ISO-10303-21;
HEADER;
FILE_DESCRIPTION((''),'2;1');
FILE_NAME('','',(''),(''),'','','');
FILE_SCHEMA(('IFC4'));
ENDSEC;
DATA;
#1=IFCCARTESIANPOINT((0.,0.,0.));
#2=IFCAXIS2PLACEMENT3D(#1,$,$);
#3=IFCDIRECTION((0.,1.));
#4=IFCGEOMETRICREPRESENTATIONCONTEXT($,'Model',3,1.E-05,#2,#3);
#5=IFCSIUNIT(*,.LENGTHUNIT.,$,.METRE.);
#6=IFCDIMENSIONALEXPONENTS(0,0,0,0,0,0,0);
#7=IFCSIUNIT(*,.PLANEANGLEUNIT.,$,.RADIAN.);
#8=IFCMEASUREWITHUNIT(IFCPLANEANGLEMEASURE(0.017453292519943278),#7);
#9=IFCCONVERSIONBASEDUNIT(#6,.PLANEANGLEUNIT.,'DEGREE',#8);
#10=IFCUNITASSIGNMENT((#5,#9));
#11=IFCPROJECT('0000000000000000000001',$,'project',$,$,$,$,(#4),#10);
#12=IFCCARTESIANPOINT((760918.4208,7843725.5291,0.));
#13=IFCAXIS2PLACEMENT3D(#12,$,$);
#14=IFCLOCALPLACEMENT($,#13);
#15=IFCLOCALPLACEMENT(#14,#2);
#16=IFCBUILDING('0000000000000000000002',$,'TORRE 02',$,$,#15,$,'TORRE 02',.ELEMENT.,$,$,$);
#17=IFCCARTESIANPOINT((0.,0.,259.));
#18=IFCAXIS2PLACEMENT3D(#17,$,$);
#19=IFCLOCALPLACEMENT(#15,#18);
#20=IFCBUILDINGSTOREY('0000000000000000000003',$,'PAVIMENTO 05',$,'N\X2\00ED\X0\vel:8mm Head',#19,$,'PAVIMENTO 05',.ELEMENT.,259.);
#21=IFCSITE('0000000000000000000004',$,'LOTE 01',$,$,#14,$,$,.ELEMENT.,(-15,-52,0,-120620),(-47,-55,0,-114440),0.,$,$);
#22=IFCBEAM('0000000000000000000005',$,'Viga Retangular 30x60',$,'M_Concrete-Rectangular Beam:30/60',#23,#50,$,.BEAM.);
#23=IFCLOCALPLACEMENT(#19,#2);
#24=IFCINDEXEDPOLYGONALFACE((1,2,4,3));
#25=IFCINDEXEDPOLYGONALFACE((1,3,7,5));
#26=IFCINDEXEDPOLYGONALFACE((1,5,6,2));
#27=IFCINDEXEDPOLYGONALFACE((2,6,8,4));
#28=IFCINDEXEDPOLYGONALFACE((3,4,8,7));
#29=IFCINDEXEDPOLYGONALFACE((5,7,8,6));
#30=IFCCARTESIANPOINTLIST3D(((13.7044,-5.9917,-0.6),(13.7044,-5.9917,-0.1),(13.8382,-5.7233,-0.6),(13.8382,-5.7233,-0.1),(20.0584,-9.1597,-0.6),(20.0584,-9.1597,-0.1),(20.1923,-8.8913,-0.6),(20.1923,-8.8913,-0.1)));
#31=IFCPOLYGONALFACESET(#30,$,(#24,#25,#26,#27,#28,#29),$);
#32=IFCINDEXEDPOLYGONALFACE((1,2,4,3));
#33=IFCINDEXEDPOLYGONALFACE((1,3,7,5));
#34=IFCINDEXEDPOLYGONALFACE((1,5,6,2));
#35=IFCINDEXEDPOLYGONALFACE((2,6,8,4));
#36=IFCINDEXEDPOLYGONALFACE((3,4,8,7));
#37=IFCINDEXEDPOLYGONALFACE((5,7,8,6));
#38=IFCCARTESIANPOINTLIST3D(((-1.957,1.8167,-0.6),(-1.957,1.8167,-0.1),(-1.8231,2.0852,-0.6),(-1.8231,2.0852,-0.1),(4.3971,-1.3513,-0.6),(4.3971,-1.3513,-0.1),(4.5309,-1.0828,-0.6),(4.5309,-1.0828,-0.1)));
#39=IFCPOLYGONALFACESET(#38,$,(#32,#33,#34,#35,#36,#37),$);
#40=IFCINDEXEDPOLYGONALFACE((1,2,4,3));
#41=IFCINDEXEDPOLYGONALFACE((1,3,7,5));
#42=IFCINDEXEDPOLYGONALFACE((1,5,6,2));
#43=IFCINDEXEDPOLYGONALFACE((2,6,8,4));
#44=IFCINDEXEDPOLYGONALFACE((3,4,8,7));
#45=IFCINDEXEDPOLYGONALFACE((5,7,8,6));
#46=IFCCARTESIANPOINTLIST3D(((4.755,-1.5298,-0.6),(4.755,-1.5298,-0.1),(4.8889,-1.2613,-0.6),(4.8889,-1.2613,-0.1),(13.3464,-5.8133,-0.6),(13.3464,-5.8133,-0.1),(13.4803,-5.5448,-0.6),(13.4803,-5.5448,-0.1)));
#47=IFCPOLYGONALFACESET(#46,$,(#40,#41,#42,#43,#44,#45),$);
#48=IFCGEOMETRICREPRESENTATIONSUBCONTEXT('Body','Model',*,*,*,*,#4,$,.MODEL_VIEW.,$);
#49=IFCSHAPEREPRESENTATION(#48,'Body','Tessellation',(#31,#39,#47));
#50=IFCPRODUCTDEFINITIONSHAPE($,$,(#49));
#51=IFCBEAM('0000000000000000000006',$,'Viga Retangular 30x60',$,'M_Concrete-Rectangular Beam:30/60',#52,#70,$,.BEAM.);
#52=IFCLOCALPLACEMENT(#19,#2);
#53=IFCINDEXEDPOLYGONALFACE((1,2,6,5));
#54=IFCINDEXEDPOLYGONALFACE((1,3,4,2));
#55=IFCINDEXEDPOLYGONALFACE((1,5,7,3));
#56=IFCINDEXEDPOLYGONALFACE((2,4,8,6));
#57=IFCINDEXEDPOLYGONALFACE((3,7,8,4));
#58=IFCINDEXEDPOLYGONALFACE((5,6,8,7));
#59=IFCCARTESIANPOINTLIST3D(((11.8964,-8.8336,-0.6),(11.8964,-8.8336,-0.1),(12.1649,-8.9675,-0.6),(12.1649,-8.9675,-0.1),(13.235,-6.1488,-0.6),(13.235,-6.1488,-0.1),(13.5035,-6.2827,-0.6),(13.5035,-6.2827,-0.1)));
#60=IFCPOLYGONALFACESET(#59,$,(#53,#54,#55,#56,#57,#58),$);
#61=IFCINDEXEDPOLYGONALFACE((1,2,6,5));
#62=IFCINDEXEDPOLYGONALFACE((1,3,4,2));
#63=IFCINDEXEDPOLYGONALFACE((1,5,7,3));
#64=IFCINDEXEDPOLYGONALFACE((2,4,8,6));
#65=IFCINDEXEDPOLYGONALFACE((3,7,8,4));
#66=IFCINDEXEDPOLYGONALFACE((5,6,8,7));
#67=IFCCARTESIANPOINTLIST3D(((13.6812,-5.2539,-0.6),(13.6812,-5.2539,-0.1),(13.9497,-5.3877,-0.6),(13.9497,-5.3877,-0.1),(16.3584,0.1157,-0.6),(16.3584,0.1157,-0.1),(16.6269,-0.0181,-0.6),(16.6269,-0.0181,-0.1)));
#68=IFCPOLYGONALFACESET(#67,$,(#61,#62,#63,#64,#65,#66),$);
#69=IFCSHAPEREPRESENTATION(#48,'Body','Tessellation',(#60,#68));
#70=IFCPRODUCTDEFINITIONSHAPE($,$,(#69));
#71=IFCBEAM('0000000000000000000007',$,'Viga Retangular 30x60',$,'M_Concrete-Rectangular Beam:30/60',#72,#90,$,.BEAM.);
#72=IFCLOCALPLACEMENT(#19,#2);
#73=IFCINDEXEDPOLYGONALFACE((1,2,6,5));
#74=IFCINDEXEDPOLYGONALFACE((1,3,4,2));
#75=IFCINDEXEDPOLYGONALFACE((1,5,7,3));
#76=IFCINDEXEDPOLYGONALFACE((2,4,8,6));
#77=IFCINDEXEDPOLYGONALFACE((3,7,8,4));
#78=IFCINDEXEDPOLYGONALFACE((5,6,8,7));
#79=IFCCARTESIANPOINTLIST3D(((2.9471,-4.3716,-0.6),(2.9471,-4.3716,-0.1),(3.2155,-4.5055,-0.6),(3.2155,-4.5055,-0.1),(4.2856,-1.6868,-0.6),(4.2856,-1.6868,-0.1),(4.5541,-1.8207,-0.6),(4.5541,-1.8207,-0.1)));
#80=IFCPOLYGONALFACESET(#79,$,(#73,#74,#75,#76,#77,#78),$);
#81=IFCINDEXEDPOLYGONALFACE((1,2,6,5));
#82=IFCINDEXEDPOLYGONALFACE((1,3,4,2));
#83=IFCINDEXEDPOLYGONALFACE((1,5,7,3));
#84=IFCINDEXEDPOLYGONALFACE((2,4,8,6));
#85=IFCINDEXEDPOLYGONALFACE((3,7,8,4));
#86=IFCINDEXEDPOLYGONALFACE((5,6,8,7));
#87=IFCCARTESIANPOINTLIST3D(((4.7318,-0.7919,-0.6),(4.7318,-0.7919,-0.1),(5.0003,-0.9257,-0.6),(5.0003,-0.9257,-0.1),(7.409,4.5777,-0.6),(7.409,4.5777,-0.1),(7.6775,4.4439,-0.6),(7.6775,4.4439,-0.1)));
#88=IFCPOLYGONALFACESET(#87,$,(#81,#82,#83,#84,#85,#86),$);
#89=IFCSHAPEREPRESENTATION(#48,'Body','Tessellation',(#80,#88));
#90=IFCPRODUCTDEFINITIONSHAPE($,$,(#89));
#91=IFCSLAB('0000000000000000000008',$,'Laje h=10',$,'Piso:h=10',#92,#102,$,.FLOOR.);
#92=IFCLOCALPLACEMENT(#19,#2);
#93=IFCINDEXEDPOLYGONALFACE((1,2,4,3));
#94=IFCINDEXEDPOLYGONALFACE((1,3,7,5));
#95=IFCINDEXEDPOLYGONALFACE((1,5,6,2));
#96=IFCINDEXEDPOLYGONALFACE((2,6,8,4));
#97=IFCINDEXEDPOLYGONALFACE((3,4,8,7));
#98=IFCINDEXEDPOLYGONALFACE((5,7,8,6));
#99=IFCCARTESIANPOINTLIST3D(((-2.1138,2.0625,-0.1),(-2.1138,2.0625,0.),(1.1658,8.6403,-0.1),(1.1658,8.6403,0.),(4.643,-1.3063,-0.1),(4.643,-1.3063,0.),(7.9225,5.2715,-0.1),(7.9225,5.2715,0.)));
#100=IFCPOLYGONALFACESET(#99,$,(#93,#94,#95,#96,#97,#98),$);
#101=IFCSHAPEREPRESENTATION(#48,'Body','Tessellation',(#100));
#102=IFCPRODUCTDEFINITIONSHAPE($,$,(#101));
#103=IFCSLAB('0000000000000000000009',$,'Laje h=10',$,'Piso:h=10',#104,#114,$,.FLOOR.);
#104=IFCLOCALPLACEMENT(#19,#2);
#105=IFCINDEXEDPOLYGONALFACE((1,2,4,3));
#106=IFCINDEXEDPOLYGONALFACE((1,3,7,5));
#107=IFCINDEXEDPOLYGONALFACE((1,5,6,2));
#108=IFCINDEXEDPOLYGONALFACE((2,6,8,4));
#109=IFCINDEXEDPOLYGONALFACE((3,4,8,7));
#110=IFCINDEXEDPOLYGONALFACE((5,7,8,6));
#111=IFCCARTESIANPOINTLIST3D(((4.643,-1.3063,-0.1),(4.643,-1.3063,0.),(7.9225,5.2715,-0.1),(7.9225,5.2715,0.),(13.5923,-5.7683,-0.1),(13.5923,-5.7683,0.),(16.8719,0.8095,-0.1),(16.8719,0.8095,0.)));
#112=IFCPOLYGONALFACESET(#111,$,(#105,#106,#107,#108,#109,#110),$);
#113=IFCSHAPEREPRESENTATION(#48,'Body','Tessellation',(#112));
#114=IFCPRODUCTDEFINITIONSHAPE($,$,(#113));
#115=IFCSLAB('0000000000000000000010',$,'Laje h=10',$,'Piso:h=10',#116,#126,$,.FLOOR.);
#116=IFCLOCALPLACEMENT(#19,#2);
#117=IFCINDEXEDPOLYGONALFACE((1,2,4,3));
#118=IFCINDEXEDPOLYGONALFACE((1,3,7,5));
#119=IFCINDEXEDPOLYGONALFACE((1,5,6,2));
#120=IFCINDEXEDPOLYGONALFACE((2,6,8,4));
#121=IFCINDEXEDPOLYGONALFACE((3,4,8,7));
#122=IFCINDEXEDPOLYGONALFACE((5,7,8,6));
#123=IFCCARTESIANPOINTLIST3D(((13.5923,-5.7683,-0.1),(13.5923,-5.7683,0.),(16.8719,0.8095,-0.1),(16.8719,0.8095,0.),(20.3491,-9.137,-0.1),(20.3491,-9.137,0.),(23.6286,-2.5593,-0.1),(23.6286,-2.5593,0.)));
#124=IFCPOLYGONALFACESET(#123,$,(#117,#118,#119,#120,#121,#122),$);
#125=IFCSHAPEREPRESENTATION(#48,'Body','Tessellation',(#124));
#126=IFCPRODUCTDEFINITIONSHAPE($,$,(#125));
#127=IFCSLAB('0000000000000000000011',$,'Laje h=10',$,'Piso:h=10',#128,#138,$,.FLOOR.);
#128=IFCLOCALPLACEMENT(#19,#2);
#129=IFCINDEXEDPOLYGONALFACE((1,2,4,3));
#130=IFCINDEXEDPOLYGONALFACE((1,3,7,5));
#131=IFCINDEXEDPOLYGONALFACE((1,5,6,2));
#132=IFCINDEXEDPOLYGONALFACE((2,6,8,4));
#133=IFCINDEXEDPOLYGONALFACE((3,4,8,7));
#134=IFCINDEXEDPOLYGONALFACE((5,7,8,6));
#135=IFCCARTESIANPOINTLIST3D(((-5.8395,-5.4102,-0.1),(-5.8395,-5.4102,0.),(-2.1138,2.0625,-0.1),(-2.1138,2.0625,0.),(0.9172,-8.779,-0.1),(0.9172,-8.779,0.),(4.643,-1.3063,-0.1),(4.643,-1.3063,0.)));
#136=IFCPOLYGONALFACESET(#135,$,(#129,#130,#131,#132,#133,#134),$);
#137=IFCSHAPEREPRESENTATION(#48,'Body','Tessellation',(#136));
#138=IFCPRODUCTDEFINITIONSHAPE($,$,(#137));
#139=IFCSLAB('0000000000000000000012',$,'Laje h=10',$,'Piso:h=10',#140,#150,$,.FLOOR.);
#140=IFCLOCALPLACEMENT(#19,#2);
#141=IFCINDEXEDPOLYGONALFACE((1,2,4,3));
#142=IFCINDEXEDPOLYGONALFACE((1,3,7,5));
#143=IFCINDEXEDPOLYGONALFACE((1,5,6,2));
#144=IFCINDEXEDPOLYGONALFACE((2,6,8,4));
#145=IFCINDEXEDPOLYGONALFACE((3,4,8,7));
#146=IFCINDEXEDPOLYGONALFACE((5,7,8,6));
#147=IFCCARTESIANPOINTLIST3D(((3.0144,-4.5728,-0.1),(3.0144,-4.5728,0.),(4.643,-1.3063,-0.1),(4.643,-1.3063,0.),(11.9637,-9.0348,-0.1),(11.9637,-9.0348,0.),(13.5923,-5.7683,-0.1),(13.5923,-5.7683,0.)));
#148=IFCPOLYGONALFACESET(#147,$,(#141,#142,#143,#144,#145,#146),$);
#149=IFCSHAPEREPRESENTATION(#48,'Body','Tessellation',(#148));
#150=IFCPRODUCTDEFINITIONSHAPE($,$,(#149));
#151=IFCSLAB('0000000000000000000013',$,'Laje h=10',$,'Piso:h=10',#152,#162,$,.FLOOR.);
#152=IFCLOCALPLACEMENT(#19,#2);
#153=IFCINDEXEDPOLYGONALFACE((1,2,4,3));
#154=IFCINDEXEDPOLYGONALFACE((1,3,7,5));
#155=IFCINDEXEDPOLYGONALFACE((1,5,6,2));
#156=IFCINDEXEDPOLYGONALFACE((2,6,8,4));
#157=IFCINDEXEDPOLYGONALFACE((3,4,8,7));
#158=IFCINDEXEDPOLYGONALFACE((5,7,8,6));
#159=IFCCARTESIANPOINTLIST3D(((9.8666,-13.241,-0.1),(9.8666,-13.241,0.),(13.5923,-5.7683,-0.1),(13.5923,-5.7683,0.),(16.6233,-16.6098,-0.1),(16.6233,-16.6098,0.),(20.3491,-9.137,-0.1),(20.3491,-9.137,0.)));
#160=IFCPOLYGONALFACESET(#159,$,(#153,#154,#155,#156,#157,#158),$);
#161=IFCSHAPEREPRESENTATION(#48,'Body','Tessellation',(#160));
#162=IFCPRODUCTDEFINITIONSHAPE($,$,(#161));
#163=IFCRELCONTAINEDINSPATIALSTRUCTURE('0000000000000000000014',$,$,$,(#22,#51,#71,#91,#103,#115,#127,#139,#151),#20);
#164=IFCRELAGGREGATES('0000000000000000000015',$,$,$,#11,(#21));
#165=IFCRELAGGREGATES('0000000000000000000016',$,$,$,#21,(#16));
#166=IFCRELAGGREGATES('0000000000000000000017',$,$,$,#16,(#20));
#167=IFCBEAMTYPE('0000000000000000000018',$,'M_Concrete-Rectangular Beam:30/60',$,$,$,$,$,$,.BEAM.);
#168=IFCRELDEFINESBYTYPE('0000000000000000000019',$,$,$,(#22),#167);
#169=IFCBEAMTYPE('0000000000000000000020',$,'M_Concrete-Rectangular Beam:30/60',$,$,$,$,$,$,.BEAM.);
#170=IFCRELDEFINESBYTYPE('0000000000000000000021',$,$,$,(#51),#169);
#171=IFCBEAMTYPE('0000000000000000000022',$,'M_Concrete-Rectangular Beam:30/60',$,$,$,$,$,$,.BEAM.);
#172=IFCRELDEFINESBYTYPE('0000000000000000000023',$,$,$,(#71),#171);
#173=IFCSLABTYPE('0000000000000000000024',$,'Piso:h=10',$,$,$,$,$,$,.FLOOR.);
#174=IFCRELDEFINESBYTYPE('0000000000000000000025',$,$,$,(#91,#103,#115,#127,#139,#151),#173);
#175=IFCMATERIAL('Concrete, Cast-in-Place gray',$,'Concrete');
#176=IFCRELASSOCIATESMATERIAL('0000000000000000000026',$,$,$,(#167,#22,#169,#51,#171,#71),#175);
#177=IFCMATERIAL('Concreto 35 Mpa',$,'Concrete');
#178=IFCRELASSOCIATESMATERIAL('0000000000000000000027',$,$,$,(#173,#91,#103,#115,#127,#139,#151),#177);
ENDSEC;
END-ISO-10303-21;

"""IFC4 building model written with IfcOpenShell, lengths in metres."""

from ifc_helpers import new_model, entity, si_unit, converted_unit, direction, frame, origin, place, context, subcontext, project, spatial, indexed_curve, outline, extrude, source, transform, mapped, material, type_object, type_shapes, element, save


model = new_model("IFC4")

# Units and contexts
model_context = context("Model", 3, precision=1e-05, world=origin(), true_north=direction((0.0, 1.0)))
body_context = subcontext(model_context, "Body", "Model", "MODEL_VIEW")
ifc_project = project(units=[si_unit("LENGTHUNIT", "METRE"), converted_unit("PLANEANGLEUNIT", "DEGREE", entity("IfcPlaneAngleMeasure", 0.017453292519943278), si_unit("PLANEANGLEUNIT", "RADIAN"), dimensions=[0, 0, 0, 0, 0, 0, 0])], contexts=[model_context])

# Site, building, storey
site_placement = place(None, frame((760918.4208, 7843725.5291, 0.0)))
site = spatial("IfcSite", under=ifc_project, at=site_placement, Name="LOTE 01", CompositionType="ELEMENT", RefLatitude=(-15, -52, 0, -120620), RefLongitude=(-47, -55, 0, -114440), RefElevation=0.0)
building_placement = place(site_placement, origin())
building = spatial("IfcBuilding", under=site, at=building_placement, Name="TORRE 02", LongName="TORRE 02", CompositionType="ELEMENT")
storey_placement = place(building_placement, frame((0.0, 0.0, 259.0)))
storey = spatial("IfcBuildingStorey", under=building, at=storey_placement, Name="PAVIMENTO 05", ObjectType="Nível:8mm Head", LongName="PAVIMENTO 05", CompositionType="ELEMENT", Elevation=259.0)

# Shared definitions
ifc_material_1 = material(Name="Concrete, Cast-in-Place gray", Category="Concrete")

# Beams
beam_type_1 = type_object("IfcBeamType", Name="M_Concrete-Rectangular Beam:30/60", PredefinedType="BEAM", material=ifc_material_1)
shared_shape_1 = source(origin(), body_context, "Body", "SweptSolid", [
    extrude(outline(indexed_curve([(-0.25, -0.15), (0.25, -0.15), (0.25, 0.15), (-0.25, 0.15), (-0.25, -0.15)], self_intersect=False)), frame((13.7713, -5.8575, 258.65), z_axis=(0.894934, -0.446198, 0.0), x_axis=(0.0, 0.0, -1.0)), (0.0, 0.0, 1.0), 7.1),
    extrude(outline(indexed_curve([(-0.25, -0.15), (0.25, -0.15), (0.25, 0.15), (-0.25, 0.15), (-0.25, -0.15)], self_intersect=False)), frame((-1.89, 1.951, 258.65), z_axis=(0.894934, -0.446198, 0.0), x_axis=(0.0, 0.0, -1.0)), (0.0, 0.0, 1.0), 7.1),
    extrude(outline(indexed_curve([(-0.25, -0.15), (0.25, -0.15), (0.25, 0.15), (-0.25, 0.15), (-0.25, -0.15)], self_intersect=False)), frame((4.822, -1.3955, 258.65), z_axis=(0.894934, -0.446198, 0.0), x_axis=(0.0, 0.0, -1.0)), (0.0, 0.0, 1.0), 9.6),
])
type_shapes(beam_type_1, [shared_shape_1])
beam_1_placement = place(storey_placement, frame((0.0, 0.0, -259.0)))
element("IfcBeam", 1, at=beam_1_placement, inside=storey, type_object=beam_type_1, material=ifc_material_1, Name="Viga Retangular 30x60", ObjectType="M_Concrete-Rectangular Beam:30/60", PredefinedType="BEAM", context=body_context, shape_type="MappedRepresentation", body=[
    mapped(shared_shape_1, transform((0.0, 0.0, 0.0), scale=1.0)),
])
beam_type_2 = type_object("IfcBeamType", Name="M_Concrete-Rectangular Beam:30/60", PredefinedType="BEAM", material=ifc_material_1)
shared_shape_2 = source(origin(), body_context, "Body", "SweptSolid", [
    extrude(outline(indexed_curve([(-0.25, -0.15), (0.25, -0.15), (0.25, 0.15), (-0.25, 0.15), (-0.25, -0.15)], self_intersect=False)), frame((12.0306, -8.9005, 258.65), z_axis=(0.446198, 0.894934, 0.0), x_axis=(0.0, 0.0, 1.0)), (0.0, 0.0, 1.0), 3.0),
    extrude(outline(indexed_curve([(-0.25, -0.15), (0.25, -0.15), (0.25, 0.15), (-0.25, 0.15), (-0.25, -0.15)], self_intersect=False)), frame((13.8154, -5.3208, 258.65), z_axis=(0.446198, 0.894934, 0.0), x_axis=(0.0, 0.0, 1.0)), (0.0, 0.0, 1.0), 6.0),
])
type_shapes(beam_type_2, [shared_shape_2])
beam_2_placement = place(storey_placement, frame((0.0, 0.0, -259.0)))
element("IfcBeam", 2, at=beam_2_placement, inside=storey, type_object=beam_type_2, material=ifc_material_1, Name="Viga Retangular 30x60", ObjectType="M_Concrete-Rectangular Beam:30/60", PredefinedType="BEAM", context=body_context, shape_type="MappedRepresentation", body=[
    mapped(shared_shape_2, transform((0.0, 0.0, 0.0), scale=1.0)),
])
beam_type_3 = type_object("IfcBeamType", Name="M_Concrete-Rectangular Beam:30/60", PredefinedType="BEAM", material=ifc_material_1)
shared_shape_3 = source(origin(), body_context, "Body", "SweptSolid", [
    extrude(outline(indexed_curve([(-0.25, -0.15), (0.25, -0.15), (0.25, 0.15), (-0.25, 0.15), (-0.25, -0.15)], self_intersect=False)), frame((3.0813, -4.4385, 258.65), z_axis=(0.446198, 0.894934, 0.0), x_axis=(0.0, 0.0, 1.0)), (0.0, 0.0, 1.0), 3.0),
    extrude(outline(indexed_curve([(-0.25, -0.15), (0.25, -0.15), (0.25, 0.15), (-0.25, 0.15), (-0.25, -0.15)], self_intersect=False)), frame((4.8661, -0.8588, 258.65), z_axis=(0.446198, 0.894934, 0.0), x_axis=(0.0, 0.0, 1.0)), (0.0, 0.0, 1.0), 6.0),
])
type_shapes(beam_type_3, [shared_shape_3])
beam_3_placement = place(storey_placement, frame((0.0, 0.0, -259.0)))
element("IfcBeam", 3, at=beam_3_placement, inside=storey, type_object=beam_type_3, material=ifc_material_1, Name="Viga Retangular 30x60", ObjectType="M_Concrete-Rectangular Beam:30/60", PredefinedType="BEAM", context=body_context, shape_type="MappedRepresentation", body=[
    mapped(shared_shape_3, transform((0.0, 0.0, 0.0), scale=1.0)),
])

# Slabs
ifc_material_2 = material(Name="Concreto 35 Mpa", Category="Concrete")
slab_type = type_object("IfcSlabType", Name="Piso:h=10", PredefinedType="FLOOR", material=ifc_material_2)
slab_1_placement = place(storey_placement, origin())
element("IfcSlab", 4, at=slab_1_placement, inside=storey, type_object=slab_type, material=ifc_material_2, Name="Laje h=10", ObjectType="Piso:h=10", PredefinedType="FLOOR", context=body_context, shape_type="SweptSolid", body=[
    extrude(outline(indexed_curve([(-3.675, -3.775), (3.675, -3.775), (3.675, 3.775), (-3.675, 3.775), (-3.675, -3.775)], self_intersect=False)), frame((2.9044, 3.667, 0.0), z_axis=(0.0, 0.0, -1.0), x_axis=(-0.446198, -0.894934, 0.0)), (0.0, 0.0, 1.0), 0.1),
])
slab_2_placement = place(storey_placement, origin())
element("IfcSlab", 5, at=slab_2_placement, inside=storey, type_object=slab_type, material=ifc_material_2, Name="Laje h=10", ObjectType="Piso:h=10", PredefinedType="FLOOR", context=body_context, shape_type="SweptSolid", body=[
    extrude(outline(indexed_curve([(-3.675, -5.0), (3.675, -5.0), (3.675, 5.0), (-3.675, 5.0), (-3.675, -5.0)], self_intersect=False)), frame((10.7574, -0.2484, 0.0), z_axis=(0.0, 0.0, -1.0), x_axis=(-0.446198, -0.894934, 0.0)), (0.0, 0.0, 1.0), 0.1),
])
slab_3_placement = place(storey_placement, origin())
element("IfcSlab", 6, at=slab_3_placement, inside=storey, type_object=slab_type, material=ifc_material_2, Name="Laje h=10", ObjectType="Piso:h=10", PredefinedType="FLOOR", context=body_context, shape_type="SweptSolid", body=[
    extrude(outline(indexed_curve([(-3.675, -3.775), (3.675, -3.775), (3.675, 3.775), (-3.675, 3.775), (-3.675, -3.775)], self_intersect=False)), frame((18.6105, -4.1638, 0.0), z_axis=(0.0, 0.0, -1.0), x_axis=(-0.446198, -0.894934, 0.0)), (0.0, 0.0, 1.0), 0.1),
])
slab_4_placement = place(storey_placement, origin())
element("IfcSlab", 7, at=slab_4_placement, inside=storey, type_object=slab_type, material=ifc_material_2, Name="Laje h=10", ObjectType="Piso:h=10", PredefinedType="FLOOR", context=body_context, shape_type="SweptSolid", body=[
    extrude(outline(indexed_curve([(-4.175, -3.775), (4.175, -3.775), (4.175, 3.775), (-4.175, 3.775), (-4.175, -3.775)], self_intersect=False)), frame((-0.5983, -3.3582, 0.0), z_axis=(0.0, 0.0, -1.0), x_axis=(-0.446198, -0.894934, 0.0)), (0.0, 0.0, 1.0), 0.1),
])
slab_5_placement = place(storey_placement, origin())
element("IfcSlab", 8, at=slab_5_placement, inside=storey, type_object=slab_type, material=ifc_material_2, Name="Laje h=10", ObjectType="Piso:h=10", PredefinedType="FLOOR", context=body_context, shape_type="SweptSolid", body=[
    extrude(outline(indexed_curve([(-1.825, -5.0), (1.825, -5.0), (1.825, 5.0), (-1.825, 5.0), (-1.825, -5.0)], self_intersect=False)), frame((8.3033, -5.1705, 0.0), z_axis=(0.0, 0.0, -1.0), x_axis=(-0.446198, -0.894934, 0.0)), (0.0, 0.0, 1.0), 0.1),
])
slab_6_placement = place(storey_placement, origin())
element("IfcSlab", 9, at=slab_6_placement, inside=storey, type_object=slab_type, material=ifc_material_2, Name="Laje h=10", ObjectType="Piso:h=10", PredefinedType="FLOOR", context=body_context, shape_type="SweptSolid", body=[
    extrude(outline(indexed_curve([(-4.175, -3.775), (4.175, -3.775), (4.175, 3.775), (-4.175, 3.775), (-4.175, -3.775)], self_intersect=False)), frame((15.1078, -11.189, 0.0), z_axis=(0.0, 0.0, -1.0), x_axis=(-0.446198, -0.894934, 0.0)), (0.0, 0.0, 1.0), 0.1),
])

save(model, "model.ifc")
